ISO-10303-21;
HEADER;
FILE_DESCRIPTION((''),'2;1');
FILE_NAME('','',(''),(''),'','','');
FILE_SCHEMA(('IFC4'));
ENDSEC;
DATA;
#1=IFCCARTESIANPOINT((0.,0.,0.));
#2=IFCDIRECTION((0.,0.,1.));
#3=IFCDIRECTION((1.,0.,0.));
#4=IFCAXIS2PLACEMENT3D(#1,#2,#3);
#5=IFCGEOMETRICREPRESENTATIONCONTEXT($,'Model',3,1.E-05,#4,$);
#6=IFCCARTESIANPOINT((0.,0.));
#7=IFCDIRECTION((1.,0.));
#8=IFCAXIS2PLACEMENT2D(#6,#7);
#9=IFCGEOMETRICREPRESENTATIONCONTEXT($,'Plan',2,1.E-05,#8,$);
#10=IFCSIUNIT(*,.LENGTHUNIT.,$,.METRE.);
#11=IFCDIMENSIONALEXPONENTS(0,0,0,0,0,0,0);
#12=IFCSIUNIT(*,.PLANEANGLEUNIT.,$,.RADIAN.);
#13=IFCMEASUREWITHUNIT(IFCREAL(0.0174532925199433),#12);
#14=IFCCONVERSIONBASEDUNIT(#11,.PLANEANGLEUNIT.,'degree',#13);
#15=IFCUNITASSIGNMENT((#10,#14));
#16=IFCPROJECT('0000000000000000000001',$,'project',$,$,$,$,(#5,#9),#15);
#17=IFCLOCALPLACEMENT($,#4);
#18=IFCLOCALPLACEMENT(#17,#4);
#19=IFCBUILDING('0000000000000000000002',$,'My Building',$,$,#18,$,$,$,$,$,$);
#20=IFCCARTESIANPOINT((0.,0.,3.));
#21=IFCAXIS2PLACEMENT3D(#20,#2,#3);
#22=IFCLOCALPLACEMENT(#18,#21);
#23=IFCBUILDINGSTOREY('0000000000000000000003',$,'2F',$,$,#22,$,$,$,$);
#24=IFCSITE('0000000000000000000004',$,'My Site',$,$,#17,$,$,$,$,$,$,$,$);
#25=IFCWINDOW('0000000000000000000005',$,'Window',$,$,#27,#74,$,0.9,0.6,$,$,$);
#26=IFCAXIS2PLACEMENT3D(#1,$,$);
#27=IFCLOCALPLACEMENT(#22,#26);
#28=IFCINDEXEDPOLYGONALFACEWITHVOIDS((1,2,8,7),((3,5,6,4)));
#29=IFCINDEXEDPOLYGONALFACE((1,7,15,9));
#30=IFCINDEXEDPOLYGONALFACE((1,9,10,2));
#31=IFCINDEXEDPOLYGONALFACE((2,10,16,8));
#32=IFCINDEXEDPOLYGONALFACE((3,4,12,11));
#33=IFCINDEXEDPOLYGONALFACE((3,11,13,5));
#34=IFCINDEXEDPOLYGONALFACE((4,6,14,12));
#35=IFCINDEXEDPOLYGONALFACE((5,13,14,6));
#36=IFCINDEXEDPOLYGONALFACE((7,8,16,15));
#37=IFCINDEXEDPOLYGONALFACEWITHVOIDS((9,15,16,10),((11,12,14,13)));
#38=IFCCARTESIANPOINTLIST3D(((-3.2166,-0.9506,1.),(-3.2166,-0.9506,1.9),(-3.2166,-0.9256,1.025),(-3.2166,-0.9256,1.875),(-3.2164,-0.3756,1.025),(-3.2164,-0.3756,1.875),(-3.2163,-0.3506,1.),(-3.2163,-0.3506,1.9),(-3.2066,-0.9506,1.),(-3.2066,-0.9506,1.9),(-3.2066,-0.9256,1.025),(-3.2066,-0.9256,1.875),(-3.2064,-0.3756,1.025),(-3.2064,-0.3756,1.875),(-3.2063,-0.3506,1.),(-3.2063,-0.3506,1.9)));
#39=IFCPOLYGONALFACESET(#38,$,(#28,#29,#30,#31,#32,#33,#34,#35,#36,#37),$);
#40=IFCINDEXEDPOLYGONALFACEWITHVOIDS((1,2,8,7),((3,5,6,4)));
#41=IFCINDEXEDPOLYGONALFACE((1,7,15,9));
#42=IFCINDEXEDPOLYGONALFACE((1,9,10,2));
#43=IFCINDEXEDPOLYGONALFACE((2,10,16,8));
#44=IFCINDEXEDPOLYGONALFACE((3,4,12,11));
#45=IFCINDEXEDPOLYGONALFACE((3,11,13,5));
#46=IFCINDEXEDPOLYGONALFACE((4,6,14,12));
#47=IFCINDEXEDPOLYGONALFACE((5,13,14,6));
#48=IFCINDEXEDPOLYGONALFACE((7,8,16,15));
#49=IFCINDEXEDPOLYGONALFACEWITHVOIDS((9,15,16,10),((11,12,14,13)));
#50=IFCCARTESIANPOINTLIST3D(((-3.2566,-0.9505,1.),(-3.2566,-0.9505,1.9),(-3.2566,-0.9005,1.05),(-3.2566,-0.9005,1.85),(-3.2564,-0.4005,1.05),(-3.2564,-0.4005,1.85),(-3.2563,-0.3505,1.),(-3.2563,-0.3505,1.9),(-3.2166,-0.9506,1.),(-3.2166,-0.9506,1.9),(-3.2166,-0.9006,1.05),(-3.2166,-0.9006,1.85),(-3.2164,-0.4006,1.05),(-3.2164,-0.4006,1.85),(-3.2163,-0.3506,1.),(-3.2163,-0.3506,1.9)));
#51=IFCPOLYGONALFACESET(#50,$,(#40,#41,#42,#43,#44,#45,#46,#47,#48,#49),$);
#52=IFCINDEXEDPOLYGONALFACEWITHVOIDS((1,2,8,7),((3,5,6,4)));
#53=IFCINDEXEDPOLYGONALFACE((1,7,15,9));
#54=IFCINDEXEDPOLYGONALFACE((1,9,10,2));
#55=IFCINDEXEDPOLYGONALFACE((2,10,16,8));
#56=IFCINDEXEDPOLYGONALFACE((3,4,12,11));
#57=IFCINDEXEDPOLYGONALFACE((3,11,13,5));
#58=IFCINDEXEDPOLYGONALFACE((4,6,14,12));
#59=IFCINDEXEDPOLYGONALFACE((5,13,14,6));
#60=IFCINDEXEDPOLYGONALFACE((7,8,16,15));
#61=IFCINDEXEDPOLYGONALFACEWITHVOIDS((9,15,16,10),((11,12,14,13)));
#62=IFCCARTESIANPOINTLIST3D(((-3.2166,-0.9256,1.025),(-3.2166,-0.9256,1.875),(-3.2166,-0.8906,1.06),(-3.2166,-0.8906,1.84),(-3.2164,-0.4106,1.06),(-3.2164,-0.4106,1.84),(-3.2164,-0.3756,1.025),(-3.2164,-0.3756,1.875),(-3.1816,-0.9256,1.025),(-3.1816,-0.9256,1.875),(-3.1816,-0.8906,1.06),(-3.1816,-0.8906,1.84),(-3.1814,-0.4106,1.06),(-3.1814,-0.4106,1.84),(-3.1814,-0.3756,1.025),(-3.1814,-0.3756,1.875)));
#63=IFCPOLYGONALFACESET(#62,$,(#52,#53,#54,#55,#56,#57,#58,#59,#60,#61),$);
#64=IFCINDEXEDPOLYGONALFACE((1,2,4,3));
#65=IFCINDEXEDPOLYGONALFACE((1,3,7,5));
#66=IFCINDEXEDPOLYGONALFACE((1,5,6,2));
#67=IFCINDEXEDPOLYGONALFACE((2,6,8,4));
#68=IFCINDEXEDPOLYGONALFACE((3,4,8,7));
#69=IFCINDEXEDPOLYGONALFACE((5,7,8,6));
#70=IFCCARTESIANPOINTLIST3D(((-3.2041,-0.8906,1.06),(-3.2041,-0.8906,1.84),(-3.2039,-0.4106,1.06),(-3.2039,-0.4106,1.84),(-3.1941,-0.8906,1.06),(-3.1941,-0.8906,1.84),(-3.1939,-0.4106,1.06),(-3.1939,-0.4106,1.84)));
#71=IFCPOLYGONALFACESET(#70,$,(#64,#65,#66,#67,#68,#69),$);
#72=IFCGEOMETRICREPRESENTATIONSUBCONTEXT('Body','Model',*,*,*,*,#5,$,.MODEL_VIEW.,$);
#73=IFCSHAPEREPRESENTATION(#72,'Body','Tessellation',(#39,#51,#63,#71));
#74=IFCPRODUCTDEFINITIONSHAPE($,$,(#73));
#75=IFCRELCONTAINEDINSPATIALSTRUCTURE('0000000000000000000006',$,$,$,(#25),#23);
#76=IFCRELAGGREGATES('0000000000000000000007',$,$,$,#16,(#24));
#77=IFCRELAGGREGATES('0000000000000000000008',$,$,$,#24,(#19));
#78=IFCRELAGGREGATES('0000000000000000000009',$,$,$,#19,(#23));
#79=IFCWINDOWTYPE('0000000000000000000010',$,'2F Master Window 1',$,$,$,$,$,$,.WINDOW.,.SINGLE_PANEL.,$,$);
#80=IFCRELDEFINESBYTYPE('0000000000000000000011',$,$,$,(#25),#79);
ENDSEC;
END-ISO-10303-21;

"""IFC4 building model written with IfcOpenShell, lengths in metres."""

from ifc_helpers import new_model, entity, si_unit, converted_unit, frame, origin_with_axes, origin_2d_with_axis, place, context, subcontext, project, spatial, line, indexed_curve, outline, extrude, shape, source, transform, mapped, type_object, type_shapes, element, save


model = new_model("IFC4")

# Units and contexts
model_context = context("Model", 3, precision=1e-05, world=origin_with_axes())
plan_context = context("Plan", 2, precision=1e-05, world=origin_2d_with_axis())
body_context_1 = subcontext(model_context, "Body", "Model", "MODEL_VIEW")
body_context_2 = subcontext(plan_context, "Body", "Plan", "PLAN_VIEW")
ifc_project = project(units=[si_unit("LENGTHUNIT", "METRE"), converted_unit("PLANEANGLEUNIT", "degree", entity("IfcReal", 0.0174532925199433), si_unit("PLANEANGLEUNIT", "RADIAN"), dimensions=[0, 0, 0, 0, 0, 0, 0])], contexts=[model_context, plan_context])

# Site, building, storey
site_placement = place(None, origin_with_axes())
site = spatial("IfcSite", under=ifc_project, at=site_placement, Name="My Site")
building_placement = place(site_placement, origin_with_axes())
building = spatial("IfcBuilding", under=site, at=building_placement, Name="My Building")
storey_placement = place(building_placement, frame((0.0, 0.0, 3.0), z_axis=(0.0, 0.0, 1.0), x_axis=(1.0, 0.0, 0.0)))
storey = spatial("IfcBuildingStorey", under=building, at=storey_placement, Name="2F")

# Window
window_type_1 = type_object("IfcWindowType", Name="2F Master Window 1", PartitioningType="SINGLE_PANEL", PredefinedType="WINDOW")
shared_shape_1 = source(origin_with_axes(), body_context_1, "Body", "SweptSolid", [
    extrude(outline(indexed_curve([(0.0, 0.0), (0.6, 0.0), (0.6, 0.9), (0.0, 0.9)], segments=[line(1, 2, 3, 4, 1)]), holes=[indexed_curve([(0.025, 0.025), (0.575, 0.025), (0.575, 0.875), (0.025, 0.875)], segments=[line(1, 2, 3, 4, 1)])]), frame((0.0, 0.09, 0.0), z_axis=(0.0, -1.0, 0.0), x_axis=(1.0, 0.0, 0.0)), (0.0, 0.0, -1.0), 0.01),
    extrude(outline(indexed_curve([(0.0, 0.0), (0.6, 0.0), (0.6, 0.9), (0.0, 0.9)], segments=[line(1, 2, 3, 4, 1)]), holes=[indexed_curve([(0.05, 0.05), (0.55, 0.05), (0.55, 0.85), (0.05, 0.85)], segments=[line(1, 2, 3, 4, 1)])]), frame((0.0, 0.05, 0.0), z_axis=(0.0, -1.0, 0.0), x_axis=(1.0, 0.0, 0.0)), (0.0, 0.0, -1.0), 0.04),
    extrude(outline(indexed_curve([(0.0, 0.0), (0.55, 0.0), (0.55, 0.85), (0.0, 0.85)], segments=[line(1, 2, 3, 4, 1)]), holes=[indexed_curve([(0.035, 0.035), (0.515, 0.035), (0.515, 0.815), (0.035, 0.815)], segments=[line(1, 2, 3, 4, 1)])]), frame((0.025, 0.09, 0.025), z_axis=(0.0, -1.0, 0.0), x_axis=(1.0, 0.0, 0.0)), (0.0, 0.0, -1.0), 0.035),
    extrude(outline(indexed_curve([(0.035, 0.035), (0.515, 0.035), (0.515, 0.815), (0.035, 0.815)], segments=[line(1, 2, 3, 4, 1)])), frame((0.025, 0.1025, 0.025), z_axis=(0.0, -1.0, 0.0), x_axis=(1.0, 0.0, 0.0)), (0.0, 0.0, -1.0), 0.01),
])
shared_shape_2 = source(origin_with_axes(), body_context_2, "Body", "Curve2D", [
    entity("IfcIndexedPolyCurve", entity("IfcCartesianPointList2D", [[0.05, 0.05], [0.55, 0.05]])),
    entity("IfcIndexedPolyCurve", entity("IfcCartesianPointList2D", [[0.0, 0.1], [0.025, 0.1], [0.025, 0.09], [0.05, 0.09], [0.05, 0.05], [0.0, 0.05]]), [entity("IfcLineIndex", [1, 2, 3, 4, 5, 6, 1])]),
    entity("IfcIndexedPolyCurve", entity("IfcCartesianPointList2D", [[0.6, 0.1], [0.575, 0.1], [0.575, 0.09], [0.55, 0.09], [0.55, 0.05], [0.6, 0.05]]), [entity("IfcLineIndex", [1, 2, 3, 4, 5, 6, 1])]),
    entity("IfcIndexedPolyCurve", entity("IfcCartesianPointList2D", [[0.025, 0.09], [0.06, 0.09], [0.06, 0.125], [0.025, 0.125]]), [entity("IfcLineIndex", [1, 2, 3, 4, 1])]),
    entity("IfcIndexedPolyCurve", entity("IfcCartesianPointList2D", [[0.575, 0.09], [0.54, 0.09], [0.54, 0.125], [0.575, 0.125]]), [entity("IfcLineIndex", [1, 2, 3, 4, 1])]),
    entity("IfcIndexedPolyCurve", entity("IfcCartesianPointList2D", [[0.06, 0.09], [0.54, 0.09]])),
    entity("IfcIndexedPolyCurve", entity("IfcCartesianPointList2D", [[0.06, 0.125], [0.54, 0.125]])),
    entity("IfcIndexedPolyCurve", entity("IfcCartesianPointList2D", [[0.06, 0.1075], [0.54, 0.1075]])),
])
type_shapes(window_type_1, [shared_shape_1, shared_shape_2])
window_1_placement = place(storey_placement, frame((-3.3063, -0.3505, 1.0), z_axis=(0.0, 0.0, 1.0), x_axis=(-0.000416, -1.0, 0.0)))
element("IfcWindow", 1, at=window_1_placement, inside=storey, type_object=window_type_1, Name="Window", OverallHeight=0.9, OverallWidth=0.6, shapes=[
    shape(body_context_1, "Body", "MappedRepresentation", [mapped(shared_shape_1, transform((0.0, 0.0, 0.0), x_axis=(1.0, 0.0, 0.0), y_axis=(0.0, 1.0, 0.0), z_axis=(0.0, 0.0, 1.0), scale=1.0))]),
    shape(body_context_2, "Body", "MappedRepresentation", [mapped(shared_shape_2, transform((0.0, 0.0, 0.0), x_axis=(1.0, 0.0, 0.0), y_axis=(0.0, 1.0, 0.0), z_axis=(0.0, 0.0, 1.0), scale=1.0))]),
])

save(model, "model.ifc")
